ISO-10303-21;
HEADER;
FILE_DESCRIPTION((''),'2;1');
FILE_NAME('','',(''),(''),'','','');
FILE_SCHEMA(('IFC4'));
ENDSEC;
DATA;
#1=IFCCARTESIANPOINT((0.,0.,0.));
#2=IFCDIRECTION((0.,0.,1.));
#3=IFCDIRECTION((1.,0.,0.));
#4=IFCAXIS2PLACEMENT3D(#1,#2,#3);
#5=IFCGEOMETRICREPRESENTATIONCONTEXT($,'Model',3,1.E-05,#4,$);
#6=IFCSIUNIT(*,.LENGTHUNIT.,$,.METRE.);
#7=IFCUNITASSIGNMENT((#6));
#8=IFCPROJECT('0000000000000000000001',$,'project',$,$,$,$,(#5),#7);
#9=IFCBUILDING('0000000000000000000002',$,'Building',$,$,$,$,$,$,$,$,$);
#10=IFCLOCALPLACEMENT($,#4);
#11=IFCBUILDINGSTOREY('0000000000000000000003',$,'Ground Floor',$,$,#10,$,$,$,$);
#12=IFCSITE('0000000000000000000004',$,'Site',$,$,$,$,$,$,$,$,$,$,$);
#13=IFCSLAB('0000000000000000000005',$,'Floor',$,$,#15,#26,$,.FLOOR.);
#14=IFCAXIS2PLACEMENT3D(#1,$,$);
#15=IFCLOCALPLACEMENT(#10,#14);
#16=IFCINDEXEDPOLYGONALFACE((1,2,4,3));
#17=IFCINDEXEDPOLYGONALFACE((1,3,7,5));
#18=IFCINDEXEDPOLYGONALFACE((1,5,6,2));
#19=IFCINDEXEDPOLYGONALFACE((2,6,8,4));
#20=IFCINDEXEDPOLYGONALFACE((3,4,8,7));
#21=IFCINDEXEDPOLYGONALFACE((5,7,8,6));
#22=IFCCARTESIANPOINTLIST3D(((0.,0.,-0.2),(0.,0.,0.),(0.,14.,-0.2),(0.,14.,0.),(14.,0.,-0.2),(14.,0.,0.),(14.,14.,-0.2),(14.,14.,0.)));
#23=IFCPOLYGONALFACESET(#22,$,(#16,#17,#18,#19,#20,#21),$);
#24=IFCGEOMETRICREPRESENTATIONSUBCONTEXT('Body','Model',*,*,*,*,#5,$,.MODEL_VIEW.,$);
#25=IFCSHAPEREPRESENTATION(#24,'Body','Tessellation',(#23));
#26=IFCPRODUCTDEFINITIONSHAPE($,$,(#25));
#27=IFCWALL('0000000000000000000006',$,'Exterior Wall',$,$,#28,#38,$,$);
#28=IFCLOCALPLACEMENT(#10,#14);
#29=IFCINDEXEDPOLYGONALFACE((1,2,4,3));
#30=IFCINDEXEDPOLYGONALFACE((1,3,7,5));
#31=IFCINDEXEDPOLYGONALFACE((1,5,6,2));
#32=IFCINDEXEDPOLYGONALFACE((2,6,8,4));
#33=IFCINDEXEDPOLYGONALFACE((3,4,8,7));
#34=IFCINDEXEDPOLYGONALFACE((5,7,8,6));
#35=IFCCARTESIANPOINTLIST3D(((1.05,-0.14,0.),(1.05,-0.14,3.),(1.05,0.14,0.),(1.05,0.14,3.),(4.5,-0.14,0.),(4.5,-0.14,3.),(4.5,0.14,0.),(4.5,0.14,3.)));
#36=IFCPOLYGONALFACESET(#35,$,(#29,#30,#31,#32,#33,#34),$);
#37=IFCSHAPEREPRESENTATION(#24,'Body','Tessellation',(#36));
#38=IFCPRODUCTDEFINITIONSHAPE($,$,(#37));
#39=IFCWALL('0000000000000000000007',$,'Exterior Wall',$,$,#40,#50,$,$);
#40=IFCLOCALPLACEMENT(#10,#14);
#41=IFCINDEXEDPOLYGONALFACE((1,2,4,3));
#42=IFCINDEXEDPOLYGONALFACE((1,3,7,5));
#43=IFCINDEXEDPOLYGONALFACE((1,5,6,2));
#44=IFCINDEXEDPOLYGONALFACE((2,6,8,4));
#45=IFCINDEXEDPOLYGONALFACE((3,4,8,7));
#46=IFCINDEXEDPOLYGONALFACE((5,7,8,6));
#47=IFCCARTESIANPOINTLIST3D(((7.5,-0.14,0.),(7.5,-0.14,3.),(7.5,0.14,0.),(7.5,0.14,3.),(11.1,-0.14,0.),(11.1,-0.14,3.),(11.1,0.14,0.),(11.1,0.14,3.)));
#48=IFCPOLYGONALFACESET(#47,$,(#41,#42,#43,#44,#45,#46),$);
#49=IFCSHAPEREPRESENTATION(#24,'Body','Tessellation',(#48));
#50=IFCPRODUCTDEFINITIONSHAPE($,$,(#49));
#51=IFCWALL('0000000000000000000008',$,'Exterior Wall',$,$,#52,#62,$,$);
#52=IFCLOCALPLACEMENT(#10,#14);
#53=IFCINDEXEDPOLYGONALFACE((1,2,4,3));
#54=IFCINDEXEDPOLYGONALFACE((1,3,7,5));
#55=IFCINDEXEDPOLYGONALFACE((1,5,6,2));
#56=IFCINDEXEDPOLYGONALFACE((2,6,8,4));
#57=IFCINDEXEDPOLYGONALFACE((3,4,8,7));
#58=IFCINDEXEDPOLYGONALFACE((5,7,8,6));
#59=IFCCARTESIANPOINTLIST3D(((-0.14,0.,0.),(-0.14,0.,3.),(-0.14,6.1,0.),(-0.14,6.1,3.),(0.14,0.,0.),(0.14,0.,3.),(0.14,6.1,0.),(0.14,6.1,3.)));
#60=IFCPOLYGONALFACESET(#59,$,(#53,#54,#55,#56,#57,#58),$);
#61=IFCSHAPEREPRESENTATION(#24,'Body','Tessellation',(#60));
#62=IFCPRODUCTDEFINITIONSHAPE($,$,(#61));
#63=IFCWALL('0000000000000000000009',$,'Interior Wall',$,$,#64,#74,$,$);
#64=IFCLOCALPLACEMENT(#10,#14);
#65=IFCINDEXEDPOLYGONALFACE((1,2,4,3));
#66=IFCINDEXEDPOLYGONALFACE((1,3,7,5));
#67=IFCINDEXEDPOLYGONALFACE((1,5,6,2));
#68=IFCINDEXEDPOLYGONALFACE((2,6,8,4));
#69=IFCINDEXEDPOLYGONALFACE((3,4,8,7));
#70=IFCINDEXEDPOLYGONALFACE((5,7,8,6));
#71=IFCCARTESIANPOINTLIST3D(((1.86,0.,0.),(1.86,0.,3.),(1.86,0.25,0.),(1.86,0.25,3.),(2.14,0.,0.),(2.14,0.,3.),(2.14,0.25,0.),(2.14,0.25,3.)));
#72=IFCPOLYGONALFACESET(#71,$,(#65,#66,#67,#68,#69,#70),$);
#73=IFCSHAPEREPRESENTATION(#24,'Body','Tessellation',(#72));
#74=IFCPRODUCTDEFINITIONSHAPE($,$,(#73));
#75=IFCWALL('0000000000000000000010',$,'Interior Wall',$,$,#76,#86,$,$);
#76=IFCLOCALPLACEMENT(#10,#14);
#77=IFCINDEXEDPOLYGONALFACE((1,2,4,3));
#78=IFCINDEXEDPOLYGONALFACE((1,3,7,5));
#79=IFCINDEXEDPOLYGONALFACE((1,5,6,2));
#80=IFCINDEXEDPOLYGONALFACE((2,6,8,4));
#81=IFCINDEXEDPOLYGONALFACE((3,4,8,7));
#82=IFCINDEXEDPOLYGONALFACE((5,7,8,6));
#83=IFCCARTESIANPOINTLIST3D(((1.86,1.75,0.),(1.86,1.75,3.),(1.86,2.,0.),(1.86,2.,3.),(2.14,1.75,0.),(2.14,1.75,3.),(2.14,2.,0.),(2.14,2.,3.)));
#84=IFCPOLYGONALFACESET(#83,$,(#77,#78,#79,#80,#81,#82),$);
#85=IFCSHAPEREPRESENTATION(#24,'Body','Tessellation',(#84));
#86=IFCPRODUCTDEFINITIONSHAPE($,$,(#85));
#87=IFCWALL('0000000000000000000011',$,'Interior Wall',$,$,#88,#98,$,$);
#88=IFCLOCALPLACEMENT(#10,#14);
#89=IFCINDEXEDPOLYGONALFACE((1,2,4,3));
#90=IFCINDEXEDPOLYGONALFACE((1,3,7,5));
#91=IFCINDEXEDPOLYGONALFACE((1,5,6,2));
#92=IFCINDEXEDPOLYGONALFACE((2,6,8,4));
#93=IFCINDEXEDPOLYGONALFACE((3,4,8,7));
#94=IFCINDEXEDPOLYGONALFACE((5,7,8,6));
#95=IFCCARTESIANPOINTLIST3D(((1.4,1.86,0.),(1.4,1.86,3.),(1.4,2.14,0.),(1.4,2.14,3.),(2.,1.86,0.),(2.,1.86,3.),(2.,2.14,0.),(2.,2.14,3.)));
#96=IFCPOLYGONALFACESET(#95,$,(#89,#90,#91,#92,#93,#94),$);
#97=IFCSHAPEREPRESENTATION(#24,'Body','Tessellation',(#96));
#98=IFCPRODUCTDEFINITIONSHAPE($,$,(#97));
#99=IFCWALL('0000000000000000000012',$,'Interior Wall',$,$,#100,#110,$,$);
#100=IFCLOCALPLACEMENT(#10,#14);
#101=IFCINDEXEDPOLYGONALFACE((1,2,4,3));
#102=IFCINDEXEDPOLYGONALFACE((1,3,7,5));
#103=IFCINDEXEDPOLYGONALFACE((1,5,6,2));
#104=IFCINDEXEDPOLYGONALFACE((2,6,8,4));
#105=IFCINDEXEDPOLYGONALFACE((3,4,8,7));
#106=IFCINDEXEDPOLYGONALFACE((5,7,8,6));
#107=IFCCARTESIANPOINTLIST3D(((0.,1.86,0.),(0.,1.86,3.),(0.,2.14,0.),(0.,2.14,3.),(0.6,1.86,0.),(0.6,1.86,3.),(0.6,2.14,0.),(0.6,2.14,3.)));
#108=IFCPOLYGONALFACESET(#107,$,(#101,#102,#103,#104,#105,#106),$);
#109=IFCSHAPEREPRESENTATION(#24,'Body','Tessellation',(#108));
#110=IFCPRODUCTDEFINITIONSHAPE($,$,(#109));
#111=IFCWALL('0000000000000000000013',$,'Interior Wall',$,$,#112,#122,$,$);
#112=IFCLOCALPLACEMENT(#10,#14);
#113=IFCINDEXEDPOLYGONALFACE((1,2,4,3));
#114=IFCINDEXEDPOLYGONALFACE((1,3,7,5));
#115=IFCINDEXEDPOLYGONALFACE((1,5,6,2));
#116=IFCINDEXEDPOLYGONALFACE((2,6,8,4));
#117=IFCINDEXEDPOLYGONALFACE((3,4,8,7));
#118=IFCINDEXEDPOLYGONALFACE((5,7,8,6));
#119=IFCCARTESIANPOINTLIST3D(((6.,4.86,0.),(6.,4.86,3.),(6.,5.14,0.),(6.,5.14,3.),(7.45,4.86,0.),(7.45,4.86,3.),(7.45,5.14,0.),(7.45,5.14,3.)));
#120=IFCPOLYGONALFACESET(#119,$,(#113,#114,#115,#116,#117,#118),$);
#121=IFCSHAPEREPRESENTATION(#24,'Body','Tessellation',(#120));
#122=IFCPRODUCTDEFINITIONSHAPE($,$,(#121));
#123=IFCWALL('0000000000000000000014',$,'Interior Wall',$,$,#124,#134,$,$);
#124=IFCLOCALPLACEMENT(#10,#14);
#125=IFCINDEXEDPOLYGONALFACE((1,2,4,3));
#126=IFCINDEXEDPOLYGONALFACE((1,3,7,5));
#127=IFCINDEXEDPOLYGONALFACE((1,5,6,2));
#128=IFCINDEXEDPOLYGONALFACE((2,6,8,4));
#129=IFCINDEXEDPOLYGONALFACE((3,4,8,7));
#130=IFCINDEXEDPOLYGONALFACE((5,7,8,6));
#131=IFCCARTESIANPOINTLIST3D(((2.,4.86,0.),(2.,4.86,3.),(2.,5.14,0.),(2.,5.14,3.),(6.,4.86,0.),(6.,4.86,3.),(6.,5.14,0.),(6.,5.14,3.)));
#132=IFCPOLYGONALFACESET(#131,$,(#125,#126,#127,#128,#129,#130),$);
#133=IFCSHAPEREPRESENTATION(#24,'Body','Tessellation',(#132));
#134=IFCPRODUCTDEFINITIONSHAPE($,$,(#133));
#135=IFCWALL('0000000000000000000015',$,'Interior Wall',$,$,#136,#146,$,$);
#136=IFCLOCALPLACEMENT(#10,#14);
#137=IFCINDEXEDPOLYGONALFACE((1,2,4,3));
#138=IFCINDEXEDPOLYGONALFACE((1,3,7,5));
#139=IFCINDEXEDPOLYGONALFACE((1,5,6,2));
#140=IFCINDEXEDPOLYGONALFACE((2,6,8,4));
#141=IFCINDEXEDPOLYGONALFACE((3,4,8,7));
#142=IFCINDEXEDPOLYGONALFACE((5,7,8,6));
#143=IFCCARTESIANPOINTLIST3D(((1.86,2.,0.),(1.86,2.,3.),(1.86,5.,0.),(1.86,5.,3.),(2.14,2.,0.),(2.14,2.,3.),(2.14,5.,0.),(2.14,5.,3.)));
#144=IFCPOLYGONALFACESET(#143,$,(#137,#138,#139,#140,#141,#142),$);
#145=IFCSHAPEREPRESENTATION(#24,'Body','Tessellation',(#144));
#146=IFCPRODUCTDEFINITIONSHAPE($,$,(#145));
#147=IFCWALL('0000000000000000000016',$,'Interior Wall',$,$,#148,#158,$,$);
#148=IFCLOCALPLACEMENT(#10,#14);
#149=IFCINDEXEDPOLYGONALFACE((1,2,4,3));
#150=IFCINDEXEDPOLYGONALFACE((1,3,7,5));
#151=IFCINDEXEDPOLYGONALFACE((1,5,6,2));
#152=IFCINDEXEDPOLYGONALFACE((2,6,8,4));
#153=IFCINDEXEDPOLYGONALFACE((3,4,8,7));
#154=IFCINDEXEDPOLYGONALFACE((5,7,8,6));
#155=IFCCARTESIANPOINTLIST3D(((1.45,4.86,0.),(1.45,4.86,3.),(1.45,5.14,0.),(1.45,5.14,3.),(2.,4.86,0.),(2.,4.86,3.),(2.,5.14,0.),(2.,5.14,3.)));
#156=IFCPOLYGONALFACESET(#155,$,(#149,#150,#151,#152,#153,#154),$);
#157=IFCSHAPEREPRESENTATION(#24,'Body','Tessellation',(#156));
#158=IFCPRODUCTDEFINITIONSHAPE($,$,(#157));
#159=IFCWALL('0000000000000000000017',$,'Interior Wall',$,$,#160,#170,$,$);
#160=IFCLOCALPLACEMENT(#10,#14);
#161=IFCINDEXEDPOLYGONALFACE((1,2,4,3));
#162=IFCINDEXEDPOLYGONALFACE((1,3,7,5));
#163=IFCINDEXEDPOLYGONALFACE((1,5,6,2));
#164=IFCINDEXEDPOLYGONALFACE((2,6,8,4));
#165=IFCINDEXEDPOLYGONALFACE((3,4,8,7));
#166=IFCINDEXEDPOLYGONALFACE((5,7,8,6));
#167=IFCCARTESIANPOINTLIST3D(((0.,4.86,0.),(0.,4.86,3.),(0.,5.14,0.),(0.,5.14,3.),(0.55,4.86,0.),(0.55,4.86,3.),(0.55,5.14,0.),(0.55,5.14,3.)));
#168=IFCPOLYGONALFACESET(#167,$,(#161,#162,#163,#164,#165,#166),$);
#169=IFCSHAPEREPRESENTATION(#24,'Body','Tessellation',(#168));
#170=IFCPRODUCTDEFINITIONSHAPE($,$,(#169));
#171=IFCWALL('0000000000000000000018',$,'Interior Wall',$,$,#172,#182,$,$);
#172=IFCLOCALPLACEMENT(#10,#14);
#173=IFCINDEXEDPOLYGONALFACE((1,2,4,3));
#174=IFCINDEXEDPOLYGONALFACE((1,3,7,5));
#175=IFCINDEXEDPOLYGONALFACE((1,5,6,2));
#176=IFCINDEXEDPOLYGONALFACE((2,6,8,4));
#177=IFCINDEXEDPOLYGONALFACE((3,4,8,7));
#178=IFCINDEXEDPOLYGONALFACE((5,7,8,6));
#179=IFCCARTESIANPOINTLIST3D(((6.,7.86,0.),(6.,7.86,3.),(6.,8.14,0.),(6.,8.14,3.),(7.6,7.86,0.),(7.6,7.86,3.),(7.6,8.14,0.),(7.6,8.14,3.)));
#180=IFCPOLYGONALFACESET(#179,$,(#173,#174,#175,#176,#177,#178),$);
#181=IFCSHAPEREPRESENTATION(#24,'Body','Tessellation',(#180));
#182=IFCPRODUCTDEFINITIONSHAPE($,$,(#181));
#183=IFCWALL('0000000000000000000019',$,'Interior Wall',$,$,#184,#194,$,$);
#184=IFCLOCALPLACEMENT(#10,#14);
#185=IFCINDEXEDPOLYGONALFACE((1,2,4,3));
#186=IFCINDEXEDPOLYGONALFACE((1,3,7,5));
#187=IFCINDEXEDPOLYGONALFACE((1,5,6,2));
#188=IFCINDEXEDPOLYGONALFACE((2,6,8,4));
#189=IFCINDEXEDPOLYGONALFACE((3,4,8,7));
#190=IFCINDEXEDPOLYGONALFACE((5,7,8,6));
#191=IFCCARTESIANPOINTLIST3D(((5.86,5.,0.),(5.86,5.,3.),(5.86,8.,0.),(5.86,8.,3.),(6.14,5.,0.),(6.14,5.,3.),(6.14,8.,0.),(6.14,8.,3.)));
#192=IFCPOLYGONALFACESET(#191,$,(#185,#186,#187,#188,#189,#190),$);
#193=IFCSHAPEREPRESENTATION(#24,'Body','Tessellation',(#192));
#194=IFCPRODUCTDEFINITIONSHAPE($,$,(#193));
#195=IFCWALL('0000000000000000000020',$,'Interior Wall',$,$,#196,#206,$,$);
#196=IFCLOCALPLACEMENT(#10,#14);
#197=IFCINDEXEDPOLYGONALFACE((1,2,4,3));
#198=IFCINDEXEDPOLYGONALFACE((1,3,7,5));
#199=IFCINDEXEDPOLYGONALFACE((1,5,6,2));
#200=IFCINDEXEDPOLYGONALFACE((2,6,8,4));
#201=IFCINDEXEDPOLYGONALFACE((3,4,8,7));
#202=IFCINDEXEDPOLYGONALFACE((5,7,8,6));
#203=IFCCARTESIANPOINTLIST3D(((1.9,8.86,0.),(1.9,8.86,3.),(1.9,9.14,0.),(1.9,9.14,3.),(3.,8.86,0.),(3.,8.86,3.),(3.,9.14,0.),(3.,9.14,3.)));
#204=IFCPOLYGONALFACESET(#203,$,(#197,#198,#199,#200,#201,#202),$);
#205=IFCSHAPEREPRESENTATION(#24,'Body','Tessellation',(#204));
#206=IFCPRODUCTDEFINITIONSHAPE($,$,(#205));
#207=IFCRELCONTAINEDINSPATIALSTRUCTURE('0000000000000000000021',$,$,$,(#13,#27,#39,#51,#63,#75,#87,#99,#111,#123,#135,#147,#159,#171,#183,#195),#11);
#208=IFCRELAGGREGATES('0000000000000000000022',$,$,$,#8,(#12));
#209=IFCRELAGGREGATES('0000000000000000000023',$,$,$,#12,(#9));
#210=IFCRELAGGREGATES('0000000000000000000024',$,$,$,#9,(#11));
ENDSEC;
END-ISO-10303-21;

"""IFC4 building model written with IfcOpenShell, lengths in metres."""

from ifc_helpers import new_model, si_unit, frame, origin_with_axes, place, context, subcontext, project, spatial, indexed_curve, outline, extrude, element, save


model = new_model("IFC4")

# Units and contexts
model_context = context("Model", 3, precision=1e-05, world=origin_with_axes())
body_context = subcontext(model_context, "Body", "Model", "MODEL_VIEW")
ifc_project = project(units=[si_unit("LENGTHUNIT", "METRE")], contexts=[model_context])

# Site, building, storey
site = spatial("IfcSite", under=ifc_project, Name="Site")
building = spatial("IfcBuilding", under=site, Name="Building")
storey_placement = place(None, origin_with_axes())
storey = spatial("IfcBuildingStorey", under=building, at=storey_placement, Name="Ground Floor")

# Slab
slab_placement = place(storey_placement, frame((0.0, 0.0, -0.2), z_axis=(0.0, 0.0, 1.0), x_axis=(1.0, 0.0, 0.0)))
element("IfcSlab", 1, at=slab_placement, inside=storey, Name="Floor", PredefinedType="FLOOR", context=body_context, shape_type="SweptSolid", body=[
    extrude(outline(indexed_curve([(0.0, 0.0), (14.0, 0.0), (14.0, 14.0), (0.0, 14.0)])), None, (0.0, 0.0, 1.0), 0.2),
])

# Walls
wall_1_placement = place(storey_placement, frame((1.05, 0.0, 0.0), z_axis=(0.0, 0.0, 1.0), x_axis=(1.0, 0.0, 0.0)))
element("IfcWall", 2, at=wall_1_placement, inside=storey, Name="Exterior Wall", context=body_context, shape_type="SweptSolid", body=[
    extrude(outline(indexed_curve([(0.0, 0.0), (0.0, 0.28), (3.45, 0.28), (3.45, 0.0), (0.0, 0.0)], self_intersect=False)), frame((0.0, -0.14, 0.0), z_axis=(0.0, 0.0, 1.0), x_axis=(1.0, 0.0, 0.0)), (0.0, 0.0, 1.0), 3.0),
])
wall_2_placement = place(storey_placement, frame((7.5, 0.0, 0.0), z_axis=(0.0, 0.0, 1.0), x_axis=(1.0, 0.0, 0.0)))
element("IfcWall", 3, at=wall_2_placement, inside=storey, Name="Exterior Wall", context=body_context, shape_type="SweptSolid", body=[
    extrude(outline(indexed_curve([(0.0, 0.0), (0.0, 0.28), (3.6, 0.28), (3.6, 0.0), (0.0, 0.0)], self_intersect=False)), frame((0.0, -0.14, 0.0), z_axis=(0.0, 0.0, 1.0), x_axis=(1.0, 0.0, 0.0)), (0.0, 0.0, 1.0), 3.0),
])
wall_3_placement = place(storey_placement, frame((0.0, 6.1, 0.0), z_axis=(0.0, 0.0, 1.0), x_axis=(0.0, -1.0, 0.0)))
element("IfcWall", 4, at=wall_3_placement, inside=storey, Name="Exterior Wall", context=body_context, shape_type="SweptSolid", body=[
    extrude(outline(indexed_curve([(0.0, 0.0), (0.0, 0.28), (6.1, 0.28), (6.1, 0.0), (0.0, 0.0)], self_intersect=False)), frame((0.0, -0.14, 0.0), z_axis=(0.0, 0.0, 1.0), x_axis=(1.0, 0.0, 0.0)), (0.0, 0.0, 1.0), 3.0),
])
for number, where, z_axis, x_axis, name in (
    (5, (2.0, 0.0, 0.0), (0.0, 0.0, 1.0), (0.0, 1.0, 0.0), "Interior Wall"),
    (6, (2.0, 1.75, 0.0), (0.0, 0.0, 1.0), (0.0, 1.0, 0.0), "Interior Wall"),
):
    element("IfcWall", number, at=place(storey_placement, frame(where, z_axis=z_axis, x_axis=x_axis)), inside=storey, Name=name, context=body_context, shape_type="SweptSolid", body=[
        extrude(outline(indexed_curve([(0.0, 0.0), (0.0, 0.28), (0.25, 0.28), (0.25, 0.0), (0.0, 0.0)], self_intersect=False)), frame((0.0, -0.14, 0.0), z_axis=(0.0, 0.0, 1.0), x_axis=(1.0, 0.0, 0.0)), (0.0, 0.0, 1.0), 3.0),
    ])
for number, where, z_axis, x_axis, name in (
    (7, (2.0, 2.0, 0.0), (0.0, 0.0, 1.0), (-1.0, 0.0, 0.0), "Interior Wall"),
    (8, (0.6, 2.0, 0.0), (0.0, 0.0, 1.0), (-1.0, 0.0, 0.0), "Interior Wall"),
):
    element("IfcWall", number, at=place(storey_placement, frame(where, z_axis=z_axis, x_axis=x_axis)), inside=storey, Name=name, context=body_context, shape_type="SweptSolid", body=[
        extrude(outline(indexed_curve([(0.0, 0.0), (0.0, 0.28), (0.6, 0.28), (0.6, 0.0), (0.0, 0.0)], self_intersect=False)), frame((0.0, -0.14, 0.0), z_axis=(0.0, 0.0, 1.0), x_axis=(1.0, 0.0, 0.0)), (0.0, 0.0, 1.0), 3.0),
    ])
wall_4_placement = place(storey_placement, frame((7.45, 5.0, 0.0), z_axis=(0.0, 0.0, 1.0), x_axis=(-1.0, 0.0, 0.0)))
element("IfcWall", 9, at=wall_4_placement, inside=storey, Name="Interior Wall", context=body_context, shape_type="SweptSolid", body=[
    extrude(outline(indexed_curve([(0.0, 0.0), (0.0, 0.28), (1.45, 0.28), (1.45, 0.0), (0.0, 0.0)], self_intersect=False)), frame((0.0, -0.14, 0.0), z_axis=(0.0, 0.0, 1.0), x_axis=(1.0, 0.0, 0.0)), (0.0, 0.0, 1.0), 3.0),
])
wall_5_placement = place(storey_placement, frame((6.0, 5.0, 0.0), z_axis=(0.0, 0.0, 1.0), x_axis=(-1.0, 0.0, 0.0)))
element("IfcWall", 10, at=wall_5_placement, inside=storey, Name="Interior Wall", context=body_context, shape_type="SweptSolid", body=[
    extrude(outline(indexed_curve([(0.0, 0.0), (0.0, 0.28), (4.0, 0.28), (4.0, 0.0), (0.0, 0.0)], self_intersect=False)), frame((0.0, -0.14, 0.0), z_axis=(0.0, 0.0, 1.0), x_axis=(1.0, 0.0, 0.0)), (0.0, 0.0, 1.0), 3.0),
])
wall_6_placement = place(storey_placement, frame((2.0, 5.0, 0.0), z_axis=(0.0, 0.0, 1.0), x_axis=(0.0, -1.0, 0.0)))
element("IfcWall", 11, at=wall_6_placement, inside=storey, Name="Interior Wall", context=body_context, shape_type="SweptSolid", body=[
    extrude(outline(indexed_curve([(0.0, 0.0), (0.0, 0.28), (3.0, 0.28), (3.0, 0.0), (0.0, 0.0)], self_intersect=False)), frame((0.0, -0.14, 0.0), z_axis=(0.0, 0.0, 1.0), x_axis=(1.0, 0.0, 0.0)), (0.0, 0.0, 1.0), 3.0),
])
for number, where, z_axis, x_axis, name in (
    (12, (2.0, 5.0, 0.0), (0.0, 0.0, 1.0), (-1.0, 0.0, 0.0), "Interior Wall"),
    (13, (0.55, 5.0, 0.0), (0.0, 0.0, 1.0), (-1.0, 0.0, 0.0), "Interior Wall"),
):
    element("IfcWall", number, at=place(storey_placement, frame(where, z_axis=z_axis, x_axis=x_axis)), inside=storey, Name=name, context=body_context, shape_type="SweptSolid", body=[
        extrude(outline(indexed_curve([(0.0, 0.0), (0.0, 0.28), (0.55, 0.28), (0.55, 0.0), (0.0, 0.0)], self_intersect=False)), frame((0.0, -0.14, 0.0), z_axis=(0.0, 0.0, 1.0), x_axis=(1.0, 0.0, 0.0)), (0.0, 0.0, 1.0), 3.0),
    ])
wall_7_placement = place(storey_placement, frame((7.6, 8.0, 0.0), z_axis=(0.0, 0.0, 1.0), x_axis=(-1.0, 0.0, 0.0)))
element("IfcWall", 14, at=wall_7_placement, inside=storey, Name="Interior Wall", context=body_context, shape_type="SweptSolid", body=[
    extrude(outline(indexed_curve([(0.0, 0.0), (0.0, 0.28), (1.6, 0.28), (1.6, 0.0), (0.0, 0.0)], self_intersect=False)), frame((0.0, -0.14, 0.0), z_axis=(0.0, 0.0, 1.0), x_axis=(1.0, 0.0, 0.0)), (0.0, 0.0, 1.0), 3.0),
])
wall_8_placement = place(storey_placement, frame((6.0, 8.0, 0.0), z_axis=(0.0, 0.0, 1.0), x_axis=(0.0, -1.0, 0.0)))
element("IfcWall", 15, at=wall_8_placement, inside=storey, Name="Interior Wall", context=body_context, shape_type="SweptSolid", body=[
    extrude(outline(indexed_curve([(0.0, 0.0), (0.0, 0.28), (3.0, 0.28), (3.0, 0.0), (0.0, 0.0)], self_intersect=False)), frame((0.0, -0.14, 0.0), z_axis=(0.0, 0.0, 1.0), x_axis=(1.0, 0.0, 0.0)), (0.0, 0.0, 1.0), 3.0),
])
for number, where, z_axis, x_axis, name in (
    (16, (3.0, 9.0, 0.0), (0.0, 0.0, 1.0), (-1.0, 0.0, 0.0), "Interior Wall"),
):
    element("IfcWall", number, at=place(storey_placement, frame(where, z_axis=z_axis, x_axis=x_axis)), inside=storey, Name=name, context=body_context, shape_type="SweptSolid", body=[
        extrude(outline(indexed_curve([(0.0, 0.0), (0.0, 0.28), (1.1, 0.28), (1.1, 0.0), (0.0, 0.0)], self_intersect=False)), frame((0.0, -0.14, 0.0), z_axis=(0.0, 0.0, 1.0), x_axis=(1.0, 0.0, 0.0)), (0.0, 0.0, 1.0), 3.0),
    ])

save(model, "model.ifc")
